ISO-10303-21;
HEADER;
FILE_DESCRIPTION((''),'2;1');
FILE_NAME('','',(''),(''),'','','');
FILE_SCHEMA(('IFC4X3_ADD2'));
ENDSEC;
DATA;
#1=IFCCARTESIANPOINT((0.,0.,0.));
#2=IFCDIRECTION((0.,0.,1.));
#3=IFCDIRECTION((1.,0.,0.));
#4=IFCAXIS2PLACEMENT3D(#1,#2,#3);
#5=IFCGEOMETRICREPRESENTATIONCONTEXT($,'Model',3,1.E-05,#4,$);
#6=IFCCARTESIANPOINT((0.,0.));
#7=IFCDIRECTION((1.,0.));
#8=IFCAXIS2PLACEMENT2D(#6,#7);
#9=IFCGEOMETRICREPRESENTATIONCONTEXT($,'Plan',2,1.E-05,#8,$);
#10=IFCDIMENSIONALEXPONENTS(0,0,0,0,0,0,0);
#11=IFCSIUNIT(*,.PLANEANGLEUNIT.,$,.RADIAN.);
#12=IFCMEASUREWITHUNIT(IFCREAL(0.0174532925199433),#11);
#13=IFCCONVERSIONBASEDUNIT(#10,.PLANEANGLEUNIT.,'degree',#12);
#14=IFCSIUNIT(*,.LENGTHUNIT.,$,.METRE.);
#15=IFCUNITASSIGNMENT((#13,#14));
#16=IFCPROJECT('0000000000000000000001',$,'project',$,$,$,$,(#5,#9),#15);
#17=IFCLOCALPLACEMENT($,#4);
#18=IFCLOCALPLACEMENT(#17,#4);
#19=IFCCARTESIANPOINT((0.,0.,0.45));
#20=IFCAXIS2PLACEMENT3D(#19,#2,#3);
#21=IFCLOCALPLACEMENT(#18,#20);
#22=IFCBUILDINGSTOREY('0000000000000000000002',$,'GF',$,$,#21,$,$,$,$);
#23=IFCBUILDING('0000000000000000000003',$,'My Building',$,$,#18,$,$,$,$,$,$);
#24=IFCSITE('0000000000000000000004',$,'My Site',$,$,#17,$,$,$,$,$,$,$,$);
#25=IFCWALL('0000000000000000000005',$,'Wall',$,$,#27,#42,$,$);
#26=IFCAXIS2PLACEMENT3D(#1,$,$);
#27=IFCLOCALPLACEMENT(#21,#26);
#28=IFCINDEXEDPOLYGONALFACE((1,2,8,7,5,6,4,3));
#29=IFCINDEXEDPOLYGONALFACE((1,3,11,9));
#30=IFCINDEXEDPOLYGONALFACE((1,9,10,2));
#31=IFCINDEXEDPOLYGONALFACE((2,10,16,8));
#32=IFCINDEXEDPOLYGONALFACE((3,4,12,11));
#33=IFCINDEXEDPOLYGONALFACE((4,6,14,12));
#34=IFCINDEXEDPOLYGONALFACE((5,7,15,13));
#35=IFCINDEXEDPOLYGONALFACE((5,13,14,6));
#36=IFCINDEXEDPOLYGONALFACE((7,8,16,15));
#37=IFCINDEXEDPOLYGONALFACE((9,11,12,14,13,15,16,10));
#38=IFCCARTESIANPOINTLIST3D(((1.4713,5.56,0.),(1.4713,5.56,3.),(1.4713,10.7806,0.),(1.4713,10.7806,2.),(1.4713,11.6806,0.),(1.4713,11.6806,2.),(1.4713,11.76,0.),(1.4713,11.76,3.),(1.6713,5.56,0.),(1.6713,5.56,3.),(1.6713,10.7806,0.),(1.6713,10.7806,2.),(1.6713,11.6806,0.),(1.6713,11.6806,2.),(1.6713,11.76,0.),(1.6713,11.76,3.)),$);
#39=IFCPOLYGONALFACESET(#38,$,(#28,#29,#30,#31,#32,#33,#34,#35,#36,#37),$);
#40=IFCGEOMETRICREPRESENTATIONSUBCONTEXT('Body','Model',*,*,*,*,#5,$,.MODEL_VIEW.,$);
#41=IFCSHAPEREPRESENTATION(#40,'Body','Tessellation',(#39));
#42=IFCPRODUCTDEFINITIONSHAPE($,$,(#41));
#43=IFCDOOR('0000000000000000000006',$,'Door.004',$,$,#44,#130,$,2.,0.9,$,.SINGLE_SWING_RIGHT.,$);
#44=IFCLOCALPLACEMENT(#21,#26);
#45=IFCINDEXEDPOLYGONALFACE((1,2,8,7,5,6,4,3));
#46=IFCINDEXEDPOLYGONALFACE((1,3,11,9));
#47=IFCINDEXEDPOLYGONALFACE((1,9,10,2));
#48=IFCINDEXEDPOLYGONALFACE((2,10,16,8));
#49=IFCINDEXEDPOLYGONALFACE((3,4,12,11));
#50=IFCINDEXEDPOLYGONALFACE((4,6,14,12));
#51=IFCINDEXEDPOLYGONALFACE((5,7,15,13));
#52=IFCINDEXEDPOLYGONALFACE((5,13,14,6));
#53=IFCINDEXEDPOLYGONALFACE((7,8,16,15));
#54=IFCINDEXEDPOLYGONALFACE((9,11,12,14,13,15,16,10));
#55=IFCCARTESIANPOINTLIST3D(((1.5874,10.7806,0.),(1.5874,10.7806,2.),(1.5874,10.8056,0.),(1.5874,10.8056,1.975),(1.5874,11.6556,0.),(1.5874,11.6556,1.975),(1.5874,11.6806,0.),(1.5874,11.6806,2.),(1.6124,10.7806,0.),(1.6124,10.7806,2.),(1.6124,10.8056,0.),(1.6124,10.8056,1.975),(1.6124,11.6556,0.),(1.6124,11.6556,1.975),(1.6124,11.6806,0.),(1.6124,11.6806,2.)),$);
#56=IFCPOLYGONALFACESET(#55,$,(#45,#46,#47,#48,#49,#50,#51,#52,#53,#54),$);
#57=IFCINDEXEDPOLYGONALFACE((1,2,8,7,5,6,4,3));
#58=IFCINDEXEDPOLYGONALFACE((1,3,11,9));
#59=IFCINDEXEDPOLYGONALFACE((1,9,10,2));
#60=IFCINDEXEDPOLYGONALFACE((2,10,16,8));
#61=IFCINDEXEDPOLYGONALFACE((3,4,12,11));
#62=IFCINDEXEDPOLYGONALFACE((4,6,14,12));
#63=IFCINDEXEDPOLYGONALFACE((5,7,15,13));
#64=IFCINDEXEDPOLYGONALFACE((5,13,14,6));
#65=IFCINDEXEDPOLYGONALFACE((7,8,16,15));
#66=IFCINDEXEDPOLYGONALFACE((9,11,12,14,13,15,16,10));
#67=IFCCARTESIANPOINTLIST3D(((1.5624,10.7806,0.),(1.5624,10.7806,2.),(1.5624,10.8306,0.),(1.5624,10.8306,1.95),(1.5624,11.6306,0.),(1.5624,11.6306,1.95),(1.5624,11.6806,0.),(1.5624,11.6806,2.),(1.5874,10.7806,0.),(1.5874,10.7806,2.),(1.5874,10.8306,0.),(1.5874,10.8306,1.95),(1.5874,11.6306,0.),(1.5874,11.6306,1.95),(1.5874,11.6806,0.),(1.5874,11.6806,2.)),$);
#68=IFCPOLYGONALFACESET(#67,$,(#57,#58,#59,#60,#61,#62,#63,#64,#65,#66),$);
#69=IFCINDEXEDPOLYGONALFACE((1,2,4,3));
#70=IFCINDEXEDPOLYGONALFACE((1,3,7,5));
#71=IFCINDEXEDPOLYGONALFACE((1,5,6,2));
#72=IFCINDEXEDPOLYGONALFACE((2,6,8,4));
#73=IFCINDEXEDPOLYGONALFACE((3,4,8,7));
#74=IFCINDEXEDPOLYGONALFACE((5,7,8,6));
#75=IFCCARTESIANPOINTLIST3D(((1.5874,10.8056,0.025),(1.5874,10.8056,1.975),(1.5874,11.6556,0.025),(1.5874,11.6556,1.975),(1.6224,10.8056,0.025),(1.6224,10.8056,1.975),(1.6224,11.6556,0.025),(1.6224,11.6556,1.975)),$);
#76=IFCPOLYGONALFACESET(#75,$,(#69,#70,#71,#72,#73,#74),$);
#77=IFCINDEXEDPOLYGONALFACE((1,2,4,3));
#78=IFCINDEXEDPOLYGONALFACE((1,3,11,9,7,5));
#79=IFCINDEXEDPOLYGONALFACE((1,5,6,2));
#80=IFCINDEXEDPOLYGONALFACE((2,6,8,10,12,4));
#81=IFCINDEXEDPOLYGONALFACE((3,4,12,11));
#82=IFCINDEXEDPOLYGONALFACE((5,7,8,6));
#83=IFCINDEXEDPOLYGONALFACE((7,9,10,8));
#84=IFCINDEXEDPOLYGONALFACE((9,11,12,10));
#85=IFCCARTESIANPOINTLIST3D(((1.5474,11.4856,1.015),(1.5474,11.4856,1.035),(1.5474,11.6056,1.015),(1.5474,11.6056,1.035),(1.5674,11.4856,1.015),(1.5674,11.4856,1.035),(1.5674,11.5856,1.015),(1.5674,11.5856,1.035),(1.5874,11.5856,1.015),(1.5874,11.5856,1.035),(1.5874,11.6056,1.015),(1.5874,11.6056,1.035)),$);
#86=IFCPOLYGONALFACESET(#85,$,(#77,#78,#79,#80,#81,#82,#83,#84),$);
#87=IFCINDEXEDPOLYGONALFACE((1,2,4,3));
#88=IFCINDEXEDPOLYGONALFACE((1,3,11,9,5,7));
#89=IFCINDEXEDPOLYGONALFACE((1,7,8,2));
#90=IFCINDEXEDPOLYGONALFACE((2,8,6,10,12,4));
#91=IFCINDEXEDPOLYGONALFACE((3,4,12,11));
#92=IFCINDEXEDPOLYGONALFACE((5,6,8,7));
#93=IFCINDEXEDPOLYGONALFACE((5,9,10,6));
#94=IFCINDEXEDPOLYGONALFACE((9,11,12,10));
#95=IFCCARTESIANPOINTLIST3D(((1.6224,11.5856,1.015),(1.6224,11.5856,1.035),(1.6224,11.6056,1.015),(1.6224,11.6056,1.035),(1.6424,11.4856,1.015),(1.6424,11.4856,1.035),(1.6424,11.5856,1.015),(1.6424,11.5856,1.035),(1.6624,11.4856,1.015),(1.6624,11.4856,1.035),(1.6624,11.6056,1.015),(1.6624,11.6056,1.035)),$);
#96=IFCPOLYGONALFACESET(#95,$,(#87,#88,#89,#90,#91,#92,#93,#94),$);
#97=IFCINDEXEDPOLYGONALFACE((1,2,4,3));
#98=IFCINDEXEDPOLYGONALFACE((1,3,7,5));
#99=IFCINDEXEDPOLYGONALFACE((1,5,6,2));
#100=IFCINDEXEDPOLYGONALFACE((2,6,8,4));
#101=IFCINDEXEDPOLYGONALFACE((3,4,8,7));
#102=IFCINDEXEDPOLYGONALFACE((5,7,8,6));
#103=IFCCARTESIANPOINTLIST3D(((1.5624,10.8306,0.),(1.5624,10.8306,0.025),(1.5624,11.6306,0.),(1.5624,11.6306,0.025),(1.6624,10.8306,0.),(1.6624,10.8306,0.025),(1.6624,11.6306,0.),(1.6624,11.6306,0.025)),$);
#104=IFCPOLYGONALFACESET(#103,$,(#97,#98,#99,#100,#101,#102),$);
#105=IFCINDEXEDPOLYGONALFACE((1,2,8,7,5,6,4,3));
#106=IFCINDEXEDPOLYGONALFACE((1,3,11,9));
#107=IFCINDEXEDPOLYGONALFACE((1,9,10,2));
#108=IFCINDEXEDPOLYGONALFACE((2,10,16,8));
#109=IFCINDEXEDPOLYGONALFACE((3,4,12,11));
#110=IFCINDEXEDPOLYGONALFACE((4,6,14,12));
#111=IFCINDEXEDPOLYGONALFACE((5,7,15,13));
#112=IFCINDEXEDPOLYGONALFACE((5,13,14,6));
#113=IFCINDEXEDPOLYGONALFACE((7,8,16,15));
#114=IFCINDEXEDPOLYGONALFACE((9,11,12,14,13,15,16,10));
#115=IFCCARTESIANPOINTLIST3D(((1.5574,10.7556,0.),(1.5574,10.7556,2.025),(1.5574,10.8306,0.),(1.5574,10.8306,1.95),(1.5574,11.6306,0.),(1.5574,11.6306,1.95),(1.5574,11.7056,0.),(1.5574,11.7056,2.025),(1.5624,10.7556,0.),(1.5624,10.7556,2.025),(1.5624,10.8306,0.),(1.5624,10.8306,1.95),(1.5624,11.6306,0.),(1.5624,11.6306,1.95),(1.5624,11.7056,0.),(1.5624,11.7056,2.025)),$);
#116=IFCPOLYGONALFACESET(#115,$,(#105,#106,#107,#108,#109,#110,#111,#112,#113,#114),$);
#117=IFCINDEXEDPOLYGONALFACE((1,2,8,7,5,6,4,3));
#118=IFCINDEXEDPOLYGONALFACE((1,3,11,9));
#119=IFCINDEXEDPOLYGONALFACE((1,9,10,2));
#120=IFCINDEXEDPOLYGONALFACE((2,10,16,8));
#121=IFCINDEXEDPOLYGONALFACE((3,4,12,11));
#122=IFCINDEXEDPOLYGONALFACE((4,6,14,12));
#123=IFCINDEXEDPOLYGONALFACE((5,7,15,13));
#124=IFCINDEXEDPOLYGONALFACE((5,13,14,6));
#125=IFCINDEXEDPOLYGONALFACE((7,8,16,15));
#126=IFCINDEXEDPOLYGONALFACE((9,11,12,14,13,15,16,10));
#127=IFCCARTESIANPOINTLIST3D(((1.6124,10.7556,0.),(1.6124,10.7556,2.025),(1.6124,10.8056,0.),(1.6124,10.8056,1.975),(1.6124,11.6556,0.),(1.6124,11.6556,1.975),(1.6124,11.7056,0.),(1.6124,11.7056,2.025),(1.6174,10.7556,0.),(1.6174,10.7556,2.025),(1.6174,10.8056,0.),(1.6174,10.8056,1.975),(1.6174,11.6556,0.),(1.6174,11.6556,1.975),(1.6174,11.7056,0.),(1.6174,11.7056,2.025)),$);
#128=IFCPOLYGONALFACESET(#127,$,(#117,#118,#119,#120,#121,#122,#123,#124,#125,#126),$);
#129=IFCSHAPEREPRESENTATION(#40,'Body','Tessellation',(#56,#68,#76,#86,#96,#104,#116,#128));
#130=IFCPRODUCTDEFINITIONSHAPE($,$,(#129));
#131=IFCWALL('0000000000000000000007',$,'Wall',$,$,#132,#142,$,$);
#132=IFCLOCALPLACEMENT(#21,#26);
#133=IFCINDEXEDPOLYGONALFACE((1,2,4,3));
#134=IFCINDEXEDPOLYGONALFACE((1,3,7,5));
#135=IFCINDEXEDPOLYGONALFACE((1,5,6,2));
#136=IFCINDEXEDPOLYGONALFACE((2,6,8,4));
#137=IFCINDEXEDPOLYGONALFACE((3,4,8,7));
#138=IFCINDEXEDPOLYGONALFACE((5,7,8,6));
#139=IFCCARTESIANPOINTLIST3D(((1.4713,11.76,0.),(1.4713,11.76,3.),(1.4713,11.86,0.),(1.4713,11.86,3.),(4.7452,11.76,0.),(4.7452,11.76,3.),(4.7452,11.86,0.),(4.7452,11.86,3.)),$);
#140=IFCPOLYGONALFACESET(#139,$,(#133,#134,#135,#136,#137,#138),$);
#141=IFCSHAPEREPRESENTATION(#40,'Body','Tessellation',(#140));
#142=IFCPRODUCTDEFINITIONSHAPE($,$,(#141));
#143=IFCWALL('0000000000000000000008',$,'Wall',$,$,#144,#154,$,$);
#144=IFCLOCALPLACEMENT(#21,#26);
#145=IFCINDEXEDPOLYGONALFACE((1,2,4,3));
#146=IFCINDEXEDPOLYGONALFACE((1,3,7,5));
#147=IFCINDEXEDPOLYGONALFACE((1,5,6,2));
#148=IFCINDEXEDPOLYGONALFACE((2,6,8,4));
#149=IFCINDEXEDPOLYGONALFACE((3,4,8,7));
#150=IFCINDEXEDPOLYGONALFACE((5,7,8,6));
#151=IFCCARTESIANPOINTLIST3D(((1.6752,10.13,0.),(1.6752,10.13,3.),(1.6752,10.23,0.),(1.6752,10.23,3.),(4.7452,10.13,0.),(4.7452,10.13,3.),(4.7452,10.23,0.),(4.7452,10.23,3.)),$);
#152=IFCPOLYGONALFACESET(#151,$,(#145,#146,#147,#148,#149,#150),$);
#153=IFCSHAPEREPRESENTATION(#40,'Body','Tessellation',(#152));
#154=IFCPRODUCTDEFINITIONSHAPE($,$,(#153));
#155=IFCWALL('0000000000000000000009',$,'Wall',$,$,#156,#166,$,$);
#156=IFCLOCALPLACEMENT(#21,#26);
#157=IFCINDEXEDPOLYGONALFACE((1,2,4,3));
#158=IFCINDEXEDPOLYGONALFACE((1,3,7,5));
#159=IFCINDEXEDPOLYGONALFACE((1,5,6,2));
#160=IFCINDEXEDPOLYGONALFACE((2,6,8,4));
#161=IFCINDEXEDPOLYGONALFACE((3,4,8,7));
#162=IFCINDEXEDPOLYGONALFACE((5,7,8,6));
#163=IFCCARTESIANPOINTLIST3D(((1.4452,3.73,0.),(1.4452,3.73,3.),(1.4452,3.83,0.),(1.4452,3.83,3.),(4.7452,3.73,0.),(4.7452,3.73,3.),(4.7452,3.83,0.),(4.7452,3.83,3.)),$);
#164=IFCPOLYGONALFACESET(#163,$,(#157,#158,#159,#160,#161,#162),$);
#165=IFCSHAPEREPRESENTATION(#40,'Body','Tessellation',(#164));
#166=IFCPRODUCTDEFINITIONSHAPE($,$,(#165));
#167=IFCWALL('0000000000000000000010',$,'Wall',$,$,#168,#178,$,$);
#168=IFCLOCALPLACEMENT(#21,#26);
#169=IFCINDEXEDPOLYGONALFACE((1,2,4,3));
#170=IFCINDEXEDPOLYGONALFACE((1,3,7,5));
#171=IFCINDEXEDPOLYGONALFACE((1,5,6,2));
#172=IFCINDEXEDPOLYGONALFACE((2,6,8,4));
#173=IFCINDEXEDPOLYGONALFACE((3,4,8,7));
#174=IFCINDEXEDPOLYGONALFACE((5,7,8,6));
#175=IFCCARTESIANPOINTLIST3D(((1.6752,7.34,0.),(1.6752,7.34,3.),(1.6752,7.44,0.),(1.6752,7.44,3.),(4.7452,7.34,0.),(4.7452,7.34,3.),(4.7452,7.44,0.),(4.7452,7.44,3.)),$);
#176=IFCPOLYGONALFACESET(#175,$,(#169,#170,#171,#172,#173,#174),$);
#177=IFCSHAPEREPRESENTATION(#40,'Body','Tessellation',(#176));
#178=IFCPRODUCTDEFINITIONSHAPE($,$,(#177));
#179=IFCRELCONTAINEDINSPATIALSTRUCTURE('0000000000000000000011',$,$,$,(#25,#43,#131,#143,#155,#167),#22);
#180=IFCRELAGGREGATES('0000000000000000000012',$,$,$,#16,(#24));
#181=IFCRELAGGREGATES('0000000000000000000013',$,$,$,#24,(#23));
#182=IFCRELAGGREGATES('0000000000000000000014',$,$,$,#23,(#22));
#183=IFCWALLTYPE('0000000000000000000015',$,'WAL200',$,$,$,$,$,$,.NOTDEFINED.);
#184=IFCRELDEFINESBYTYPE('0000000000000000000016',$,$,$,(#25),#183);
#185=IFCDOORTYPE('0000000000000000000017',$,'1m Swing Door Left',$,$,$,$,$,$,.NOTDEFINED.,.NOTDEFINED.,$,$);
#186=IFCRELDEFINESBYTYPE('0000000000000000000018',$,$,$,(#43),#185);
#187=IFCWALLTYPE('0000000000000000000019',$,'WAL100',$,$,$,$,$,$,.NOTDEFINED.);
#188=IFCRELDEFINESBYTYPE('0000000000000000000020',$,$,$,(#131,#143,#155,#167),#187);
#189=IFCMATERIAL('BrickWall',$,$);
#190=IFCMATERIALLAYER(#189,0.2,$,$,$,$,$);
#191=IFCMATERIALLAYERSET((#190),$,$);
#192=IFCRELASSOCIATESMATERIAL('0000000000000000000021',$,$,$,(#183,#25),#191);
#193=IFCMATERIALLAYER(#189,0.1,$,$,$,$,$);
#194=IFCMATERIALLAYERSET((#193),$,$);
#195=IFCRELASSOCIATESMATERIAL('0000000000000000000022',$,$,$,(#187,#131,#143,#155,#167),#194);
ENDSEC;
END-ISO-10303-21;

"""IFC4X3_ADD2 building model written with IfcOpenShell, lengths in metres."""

from ifc_helpers import new_model, entity, si_unit, converted_unit, frame, origin_with_axes, origin_2d_with_axis, place, context, subcontext, project, spatial, line, indexed_curve, outline, extrude, shape, source, transform, mapped, material, layer, layer_set, layer_usage, type_object, type_shapes, element, fill, save


model = new_model("IFC4X3_ADD2")

# Units and contexts
model_context = context("Model", 3, precision=1e-05, world=origin_with_axes())
plan_context = context("Plan", 2, precision=1e-05, world=origin_2d_with_axis())
body_context_1 = subcontext(model_context, "Body", "Model", "MODEL_VIEW")
body_context_2 = subcontext(plan_context, "Body", "Plan", "PLAN_VIEW")
ifc_project = project(units=[converted_unit("PLANEANGLEUNIT", "degree", entity("IfcReal", 0.0174532925199433), si_unit("PLANEANGLEUNIT", "RADIAN"), dimensions=[0, 0, 0, 0, 0, 0, 0]), si_unit("LENGTHUNIT", "METRE")], contexts=[model_context, plan_context])

# Site, building, storey
site_placement = place(None, origin_with_axes())
site = spatial("IfcSite", under=ifc_project, at=site_placement, Name="My Site")
building_placement = place(site_placement, origin_with_axes())
building = spatial("IfcBuilding", under=site, at=building_placement, Name="My Building")
storey_placement = place(building_placement, frame((0.0, 0.0, 0.45), z_axis=(0.0, 0.0, 1.0), x_axis=(1.0, 0.0, 0.0)))
storey = spatial("IfcBuildingStorey", under=building, at=storey_placement, Name="GF")

# Shared definitions
ifc_material_1 = material(Name="BrickWall")

# Wall, opening, door
ifc_layer_1 = layer(ifc_material_1, 0.2)
ifc_layer_set_1 = layer_set([ifc_layer_1])
wall_type_1 = type_object("IfcWallType", Name="WAL200", PredefinedType="NOTDEFINED", material=ifc_layer_set_1)
ifc_layer_usage_1 = layer_usage(ifc_layer_set_1, "AXIS2", "POSITIVE", 0.0)
wall_1_placement = place(storey_placement, frame((1.6713, 5.56, 0.0), z_axis=(0.0, 0.0, 1.0), x_axis=(0.0, 1.0, 0.0)))
wall_1 = element("IfcWall", 1, at=wall_1_placement, inside=storey, type_object=wall_type_1, material=ifc_layer_usage_1, Name="Wall", context=body_context_1, shape_type="SweptSolid", body=[
    extrude(outline(indexed_curve([(0.0, 0.0), (0.0, 0.2), (6.2, 0.2), (6.2, 0.0), (0.0, 0.0)], self_intersect=False)), origin_with_axes(), (0.0, 0.0, 1.0), 3.0),
])
shared_shape_1 = source(origin_with_axes(), body_context_1, "Body", "SweptSolid", [
    extrude(outline(indexed_curve([(0.0, 0.0), (0.9, 0.0), (0.9, 2.0), (0.0, 2.0)], segments=[line(1, 2, 3, 4, 1)])), frame((0.0, -0.6, 0.0), z_axis=(0.0, -1.0, 0.0), x_axis=(1.0, 0.0, 0.0)), (0.0, 0.0, -1.0), 1.2),
])
opening_1_placement = place(wall_1_placement, frame((6.1205, 0.109, 0.0), z_axis=(0.0, 0.0, 1.0), x_axis=(-1.0, 0.0, 0.0)))
opening_1 = element("IfcOpeningElement", 2, at=opening_1_placement, cuts=wall_1, PredefinedType="OPENING", context=body_context_1, shape_type="MappedRepresentation", body=[
    mapped(shared_shape_1, transform((0.0, 0.0, 0.0), x_axis=(1.0, 0.0, 0.0), y_axis=(0.0, 1.0, 0.0), z_axis=(0.0, 0.0, 1.0), scale=1.0)),
])
door_type_1 = type_object("IfcDoorType", Name="1m Swing Door Left", OperationType="NOTDEFINED", PredefinedType="NOTDEFINED")
shared_shape_2 = source(origin_with_axes(), body_context_1, "Body", "SweptSolid", [
    extrude(outline(indexed_curve([(0.0, 0.0), (0.0, 2.0), (0.9, 2.0), (0.9, 0.0), (0.875, 0.0), (0.875, 1.975), (0.025, 1.975), (0.025, 0.0)], segments=[line(1, 2, 3, 4, 5, 6, 7, 8, 1)])), frame((0.0, 0.025, 0.0), z_axis=(0.0, -1.0, 0.0), x_axis=(1.0, 0.0, 0.0)), (0.0, 0.0, -1.0), 0.025),
    extrude(outline(indexed_curve([(0.0, 0.0), (0.0, 2.0), (0.9, 2.0), (0.9, 0.0), (0.85, 0.0), (0.85, 1.95), (0.05, 1.95), (0.05, 0.0)], segments=[line(1, 2, 3, 4, 5, 6, 7, 8, 1)])), frame((0.0, 0.0, 0.0), z_axis=(0.0, -1.0, 0.0), x_axis=(1.0, 0.0, 0.0)), (0.0, 0.0, -1.0), 0.025),
    extrude(outline(indexed_curve([(0.0, 0.0), (0.85, 0.0), (0.85, 0.035), (0.0, 0.035)], segments=[line(1, 2, 3, 4, 1)])), frame((0.025, 0.025, 0.025), z_axis=(0.0, 0.0, 1.0), x_axis=(1.0, 0.0, 0.0)), (0.0, 0.0, 1.0), 1.95),
    extrude(outline(indexed_curve([(0.0, 0.0), (0.0, -0.04), (0.12, -0.04), (0.12, -0.02), (0.02, -0.02), (0.02, 0.0)], segments=[line(1, 2, 3, 4, 5, 6, 1)])), frame((0.075, 0.025, 1.015), z_axis=(0.0, 0.0, 1.0), x_axis=(1.0, 0.0, 0.0)), (0.0, 0.0, 1.0), 0.02),
    extrude(outline(indexed_curve([(0.0, 0.0), (0.0, 0.04), (0.12, 0.04), (0.12, 0.02), (0.02, 0.02), (0.02, 0.0)], segments=[line(1, 2, 3, 4, 5, 6, 1)])), frame((0.075, 0.06, 1.015), z_axis=(0.0, 0.0, 1.0), x_axis=(1.0, 0.0, 0.0)), (0.0, 0.0, 1.0), 0.02),
    extrude(outline(indexed_curve([(0.0, 0.0), (0.8, 0.0), (0.8, 0.1), (0.0, 0.1)], segments=[line(1, 2, 3, 4, 1)])), frame((0.05, 0.0, 0.0), z_axis=(0.0, 0.0, 1.0), x_axis=(1.0, 0.0, 0.0)), (0.0, 0.0, 1.0), 0.025),
    extrude(outline(indexed_curve([(0.0, 0.0), (0.0, 2.025), (0.95, 2.025), (0.95, 0.0), (0.875, 0.0), (0.875, 1.95), (0.075, 1.95), (0.075, 0.0)], segments=[line(1, 2, 3, 4, 5, 6, 7, 8, 1)])), frame((-0.025, -0.005, 0.0), z_axis=(0.0, -1.0, 0.0), x_axis=(1.0, 0.0, 0.0)), (0.0, 0.0, -1.0), 0.005),
    extrude(outline(indexed_curve([(0.0, 0.0), (0.0, 2.025), (0.95, 2.025), (0.95, 0.0), (0.9, 0.0), (0.9, 1.975), (0.05, 1.975), (0.05, 0.0)], segments=[line(1, 2, 3, 4, 5, 6, 7, 8, 1)])), frame((-0.025, 0.05, 0.0), z_axis=(0.0, -1.0, 0.0), x_axis=(1.0, 0.0, 0.0)), (0.0, 0.0, -1.0), 0.005),
])
shared_shape_3 = source(origin_with_axes(), body_context_2, "Body", "Curve2D", [
    entity("IfcIndexedPolyCurve", entity("IfcCartesianPointList2D", [[0.0, 0.0], [0.0, 0.05], [0.025, 0.05], [0.025, 0.025], [0.05, 0.025], [0.05, 0.0]]), [entity("IfcLineIndex", [1, 2, 3, 4, 5, 6, 1])]),
    entity("IfcIndexedPolyCurve", entity("IfcCartesianPointList2D", [[0.9, 0.0], [0.9, 0.05], [0.875, 0.05], [0.875, 0.025], [0.85, 0.025], [0.85, 0.0]]), [entity("IfcLineIndex", [1, 2, 3, 4, 5, 6, 1])]),
    entity("IfcTrimmedCurve", entity("IfcEllipse", entity("IfcAxis2Placement2D", entity("IfcCartesianPoint", [0.84, 0.05]), entity("IfcDirection", [1.0, 0.0])), 0.815, 0.85), [entity("IfcCartesianPoint", [0.84, 0.9])], [entity("IfcCartesianPoint", [0.025, 0.05])], True, "CARTESIAN"),
    entity("IfcIndexedPolyCurve", entity("IfcCartesianPointList2D", [[0.875, 0.05], [0.84, 0.05], [0.84, 0.9], [0.875, 0.9]]), [entity("IfcLineIndex", [1, 2, 3, 4, 1])]),
])
type_shapes(door_type_1, [shared_shape_2, shared_shape_3])
door_1_placement = place(opening_1_placement, frame((0.0, 0.0, 0.0), z_axis=(0.0, 0.0, 1.0), x_axis=(1.0, 0.0, 0.0)))
door_1 = element("IfcDoor", 3, at=door_1_placement, inside=storey, type_object=door_type_1, Name="Door.004", OperationType="SINGLE_SWING_RIGHT", OverallHeight=2.0, OverallWidth=0.9, shapes=[
    shape(body_context_1, "Body", "MappedRepresentation", [mapped(shared_shape_2, transform((0.0, 0.0, 0.0), x_axis=(1.0, 0.0, 0.0), y_axis=(0.0, 1.0, 0.0), z_axis=(0.0, 0.0, 1.0), scale=1.0))]),
    shape(body_context_2, "Body", "MappedRepresentation", [mapped(shared_shape_3, transform((0.0, 0.0, 0.0), x_axis=(1.0, 0.0, 0.0), y_axis=(0.0, 1.0, 0.0), z_axis=(0.0, 0.0, 1.0), scale=1.0))]),
])
fill(opening_1, door_1)

# Walls
ifc_layer_2 = layer(ifc_material_1, 0.1)
ifc_layer_set_2 = layer_set([ifc_layer_2])
ifc_layer_usage_2 = layer_usage(ifc_layer_set_2, "AXIS2", "POSITIVE", 0.0)
wall_type_2 = type_object("IfcWallType", Name="WAL100", PredefinedType="NOTDEFINED", material=ifc_layer_set_2)
wall_2_placement = place(storey_placement, frame((1.4713, 11.76, 0.0), z_axis=(0.0, 0.0, 1.0), x_axis=(1.0, 0.0, 0.0)))
element("IfcWall", 4, at=wall_2_placement, inside=storey, type_object=wall_type_2, material=ifc_layer_usage_2, Name="Wall", context=body_context_1, shape_type="SweptSolid", body=[
    extrude(outline(indexed_curve([(0.0, 0.0), (0.0, 0.1), (3.2738, 0.1), (3.2738, 0.0), (0.0, 0.0)], self_intersect=False)), origin_with_axes(), (0.0, 0.0, 1.0), 3.0),
])
ifc_layer_usage_3 = layer_usage(ifc_layer_set_2, "AXIS2", "POSITIVE", 0.0)
wall_3_placement = place(storey_placement, frame((1.6752, 10.13, 0.0), z_axis=(0.0, 0.0, 1.0), x_axis=(1.0, 0.0, 0.0)))
element("IfcWall", 5, at=wall_3_placement, inside=storey, type_object=wall_type_2, material=ifc_layer_usage_3, Name="Wall", context=body_context_1, shape_type="SweptSolid", body=[
    extrude(outline(indexed_curve([(0.0, 0.0), (0.0, 0.1), (3.0699, 0.1), (3.0699, 0.0), (0.0, 0.0)], self_intersect=False)), origin_with_axes(), (0.0, 0.0, 1.0), 3.0),
])
ifc_layer_usage_4 = layer_usage(ifc_layer_set_2, "AXIS2", "POSITIVE", 0.0)
wall_4_placement = place(storey_placement, frame((1.4452, 3.73, 0.0), z_axis=(0.0, 0.0, 1.0), x_axis=(1.0, 0.0, 0.0)))
element("IfcWall", 6, at=wall_4_placement, inside=storey, type_object=wall_type_2, material=ifc_layer_usage_4, Name="Wall", context=body_context_1, shape_type="SweptSolid", body=[
    extrude(outline(indexed_curve([(0.0, 0.0), (0.0, 0.1), (3.3, 0.1), (3.3, 0.0), (0.0, 0.0)], self_intersect=False)), origin_with_axes(), (0.0, 0.0, 1.0), 3.0),
])
ifc_layer_usage_5 = layer_usage(ifc_layer_set_2, "AXIS2", "POSITIVE", 0.0)
wall_5_placement = place(storey_placement, frame((1.6752, 7.34, 0.0), z_axis=(0.0, 0.0, 1.0), x_axis=(1.0, 0.0, 0.0)))
element("IfcWall", 7, at=wall_5_placement, inside=storey, type_object=wall_type_2, material=ifc_layer_usage_5, Name="Wall", context=body_context_1, shape_type="SweptSolid", body=[
    extrude(outline(indexed_curve([(0.0, 0.0), (0.0, 0.1), (3.0699, 0.1), (3.0699, 0.0), (0.0, 0.0)], self_intersect=False)), origin_with_axes(), (0.0, 0.0, 1.0), 3.0),
])

save(model, "model.ifc")
